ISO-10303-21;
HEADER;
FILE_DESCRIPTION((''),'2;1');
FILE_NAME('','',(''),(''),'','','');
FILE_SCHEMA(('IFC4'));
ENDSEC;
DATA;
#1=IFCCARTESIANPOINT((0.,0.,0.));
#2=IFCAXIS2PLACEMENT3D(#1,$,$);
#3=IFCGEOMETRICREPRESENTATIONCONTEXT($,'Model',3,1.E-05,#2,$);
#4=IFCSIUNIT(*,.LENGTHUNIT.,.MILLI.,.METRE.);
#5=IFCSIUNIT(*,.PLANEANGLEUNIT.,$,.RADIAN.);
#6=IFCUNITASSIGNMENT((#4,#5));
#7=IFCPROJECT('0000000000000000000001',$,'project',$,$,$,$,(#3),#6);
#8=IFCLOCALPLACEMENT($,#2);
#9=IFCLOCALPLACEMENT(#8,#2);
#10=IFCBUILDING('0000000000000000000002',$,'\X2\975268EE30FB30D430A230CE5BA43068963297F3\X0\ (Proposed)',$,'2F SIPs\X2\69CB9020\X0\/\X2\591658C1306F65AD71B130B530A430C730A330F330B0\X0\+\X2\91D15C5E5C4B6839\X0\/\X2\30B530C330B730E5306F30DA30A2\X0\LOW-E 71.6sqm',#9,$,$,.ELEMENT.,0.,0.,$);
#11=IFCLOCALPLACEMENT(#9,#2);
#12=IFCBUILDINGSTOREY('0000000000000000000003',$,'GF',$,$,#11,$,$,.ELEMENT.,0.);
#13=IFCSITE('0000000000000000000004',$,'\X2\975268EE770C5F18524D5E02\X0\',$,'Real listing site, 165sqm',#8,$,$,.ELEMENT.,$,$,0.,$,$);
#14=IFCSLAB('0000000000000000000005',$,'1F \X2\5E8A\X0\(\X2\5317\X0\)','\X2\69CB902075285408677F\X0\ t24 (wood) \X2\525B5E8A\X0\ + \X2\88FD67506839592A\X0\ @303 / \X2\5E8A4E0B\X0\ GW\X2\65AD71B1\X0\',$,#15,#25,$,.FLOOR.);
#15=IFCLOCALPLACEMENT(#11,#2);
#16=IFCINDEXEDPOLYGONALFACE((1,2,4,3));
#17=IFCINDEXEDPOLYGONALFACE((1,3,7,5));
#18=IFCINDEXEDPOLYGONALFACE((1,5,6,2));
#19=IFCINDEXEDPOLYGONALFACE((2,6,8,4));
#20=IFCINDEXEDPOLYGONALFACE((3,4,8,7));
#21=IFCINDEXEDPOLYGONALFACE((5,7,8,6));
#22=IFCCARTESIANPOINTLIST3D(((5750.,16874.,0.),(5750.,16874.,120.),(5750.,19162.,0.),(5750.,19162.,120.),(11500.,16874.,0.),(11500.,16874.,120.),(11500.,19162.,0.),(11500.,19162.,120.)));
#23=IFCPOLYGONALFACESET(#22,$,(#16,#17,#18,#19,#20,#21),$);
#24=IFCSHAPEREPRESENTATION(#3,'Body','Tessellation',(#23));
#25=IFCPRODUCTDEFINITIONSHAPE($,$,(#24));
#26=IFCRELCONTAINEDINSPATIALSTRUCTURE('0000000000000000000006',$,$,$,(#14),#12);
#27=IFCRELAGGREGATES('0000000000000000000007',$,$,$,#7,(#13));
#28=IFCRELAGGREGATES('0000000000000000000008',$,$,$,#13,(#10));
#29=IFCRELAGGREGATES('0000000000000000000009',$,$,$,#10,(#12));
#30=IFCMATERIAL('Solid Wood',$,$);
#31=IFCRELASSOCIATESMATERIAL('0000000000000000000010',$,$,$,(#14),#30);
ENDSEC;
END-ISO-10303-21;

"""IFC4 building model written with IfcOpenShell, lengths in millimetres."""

from ifc_helpers import new_model, si_unit, frame, frame_2d, origin, place, context, project, spatial, rectangle, extrude, material, element, save


model = new_model("IFC4")

# Units and contexts
model_context = context("Model", 3, precision=1e-05, world=origin())
ifc_project = project(units=[si_unit("LENGTHUNIT", "METRE", prefix="MILLI"), si_unit("PLANEANGLEUNIT", "RADIAN")], contexts=[model_context])

# Site, building, storey
site_placement = place(None, origin())
site = spatial("IfcSite", under=ifc_project, at=site_placement, Name="青森県弘前市", ObjectType="Real listing site, 165sqm", CompositionType="ELEMENT", RefElevation=0.0)
building_placement = place(site_placement, origin())
building = spatial("IfcBuilding", under=site, at=building_placement, Name="青森・ピアノ室と防音 (Proposed)", ObjectType="2F SIPs構造/外壁は断熱サイディング+金属屋根/サッシュはペアLOW-E 71.6sqm", CompositionType="ELEMENT", ElevationOfRefHeight=0.0, ElevationOfTerrain=0.0)
storey_placement = place(building_placement, origin())
storey = spatial("IfcBuildingStorey", under=building, at=storey_placement, Name="GF", CompositionType="ELEMENT", Elevation=0.0)

# Shared definitions
ifc_material_1 = material(Name="Solid Wood")

# Slab
slab_placement = place(storey_placement, frame((2875.0, 8437.0, 0.0)))
element("IfcSlab", 1, at=slab_placement, inside=storey, material=ifc_material_1, Name="1F 床(北)", Description="構造用合板 t24 (wood) 剛床 + 製材根太 @303 / 床下 GW断熱", PredefinedType="FLOOR", context=model_context, shape_type="SweptSolid", body=[
    extrude(rectangle(XDim=5750.0, YDim=2288.0, at=frame_2d((2875.0, 1144.0))), frame((2875.0, 8437.0, 0.0)), (0.0, 0.0, 1.0), 120.0),
])

save(model, "model.ifc")
